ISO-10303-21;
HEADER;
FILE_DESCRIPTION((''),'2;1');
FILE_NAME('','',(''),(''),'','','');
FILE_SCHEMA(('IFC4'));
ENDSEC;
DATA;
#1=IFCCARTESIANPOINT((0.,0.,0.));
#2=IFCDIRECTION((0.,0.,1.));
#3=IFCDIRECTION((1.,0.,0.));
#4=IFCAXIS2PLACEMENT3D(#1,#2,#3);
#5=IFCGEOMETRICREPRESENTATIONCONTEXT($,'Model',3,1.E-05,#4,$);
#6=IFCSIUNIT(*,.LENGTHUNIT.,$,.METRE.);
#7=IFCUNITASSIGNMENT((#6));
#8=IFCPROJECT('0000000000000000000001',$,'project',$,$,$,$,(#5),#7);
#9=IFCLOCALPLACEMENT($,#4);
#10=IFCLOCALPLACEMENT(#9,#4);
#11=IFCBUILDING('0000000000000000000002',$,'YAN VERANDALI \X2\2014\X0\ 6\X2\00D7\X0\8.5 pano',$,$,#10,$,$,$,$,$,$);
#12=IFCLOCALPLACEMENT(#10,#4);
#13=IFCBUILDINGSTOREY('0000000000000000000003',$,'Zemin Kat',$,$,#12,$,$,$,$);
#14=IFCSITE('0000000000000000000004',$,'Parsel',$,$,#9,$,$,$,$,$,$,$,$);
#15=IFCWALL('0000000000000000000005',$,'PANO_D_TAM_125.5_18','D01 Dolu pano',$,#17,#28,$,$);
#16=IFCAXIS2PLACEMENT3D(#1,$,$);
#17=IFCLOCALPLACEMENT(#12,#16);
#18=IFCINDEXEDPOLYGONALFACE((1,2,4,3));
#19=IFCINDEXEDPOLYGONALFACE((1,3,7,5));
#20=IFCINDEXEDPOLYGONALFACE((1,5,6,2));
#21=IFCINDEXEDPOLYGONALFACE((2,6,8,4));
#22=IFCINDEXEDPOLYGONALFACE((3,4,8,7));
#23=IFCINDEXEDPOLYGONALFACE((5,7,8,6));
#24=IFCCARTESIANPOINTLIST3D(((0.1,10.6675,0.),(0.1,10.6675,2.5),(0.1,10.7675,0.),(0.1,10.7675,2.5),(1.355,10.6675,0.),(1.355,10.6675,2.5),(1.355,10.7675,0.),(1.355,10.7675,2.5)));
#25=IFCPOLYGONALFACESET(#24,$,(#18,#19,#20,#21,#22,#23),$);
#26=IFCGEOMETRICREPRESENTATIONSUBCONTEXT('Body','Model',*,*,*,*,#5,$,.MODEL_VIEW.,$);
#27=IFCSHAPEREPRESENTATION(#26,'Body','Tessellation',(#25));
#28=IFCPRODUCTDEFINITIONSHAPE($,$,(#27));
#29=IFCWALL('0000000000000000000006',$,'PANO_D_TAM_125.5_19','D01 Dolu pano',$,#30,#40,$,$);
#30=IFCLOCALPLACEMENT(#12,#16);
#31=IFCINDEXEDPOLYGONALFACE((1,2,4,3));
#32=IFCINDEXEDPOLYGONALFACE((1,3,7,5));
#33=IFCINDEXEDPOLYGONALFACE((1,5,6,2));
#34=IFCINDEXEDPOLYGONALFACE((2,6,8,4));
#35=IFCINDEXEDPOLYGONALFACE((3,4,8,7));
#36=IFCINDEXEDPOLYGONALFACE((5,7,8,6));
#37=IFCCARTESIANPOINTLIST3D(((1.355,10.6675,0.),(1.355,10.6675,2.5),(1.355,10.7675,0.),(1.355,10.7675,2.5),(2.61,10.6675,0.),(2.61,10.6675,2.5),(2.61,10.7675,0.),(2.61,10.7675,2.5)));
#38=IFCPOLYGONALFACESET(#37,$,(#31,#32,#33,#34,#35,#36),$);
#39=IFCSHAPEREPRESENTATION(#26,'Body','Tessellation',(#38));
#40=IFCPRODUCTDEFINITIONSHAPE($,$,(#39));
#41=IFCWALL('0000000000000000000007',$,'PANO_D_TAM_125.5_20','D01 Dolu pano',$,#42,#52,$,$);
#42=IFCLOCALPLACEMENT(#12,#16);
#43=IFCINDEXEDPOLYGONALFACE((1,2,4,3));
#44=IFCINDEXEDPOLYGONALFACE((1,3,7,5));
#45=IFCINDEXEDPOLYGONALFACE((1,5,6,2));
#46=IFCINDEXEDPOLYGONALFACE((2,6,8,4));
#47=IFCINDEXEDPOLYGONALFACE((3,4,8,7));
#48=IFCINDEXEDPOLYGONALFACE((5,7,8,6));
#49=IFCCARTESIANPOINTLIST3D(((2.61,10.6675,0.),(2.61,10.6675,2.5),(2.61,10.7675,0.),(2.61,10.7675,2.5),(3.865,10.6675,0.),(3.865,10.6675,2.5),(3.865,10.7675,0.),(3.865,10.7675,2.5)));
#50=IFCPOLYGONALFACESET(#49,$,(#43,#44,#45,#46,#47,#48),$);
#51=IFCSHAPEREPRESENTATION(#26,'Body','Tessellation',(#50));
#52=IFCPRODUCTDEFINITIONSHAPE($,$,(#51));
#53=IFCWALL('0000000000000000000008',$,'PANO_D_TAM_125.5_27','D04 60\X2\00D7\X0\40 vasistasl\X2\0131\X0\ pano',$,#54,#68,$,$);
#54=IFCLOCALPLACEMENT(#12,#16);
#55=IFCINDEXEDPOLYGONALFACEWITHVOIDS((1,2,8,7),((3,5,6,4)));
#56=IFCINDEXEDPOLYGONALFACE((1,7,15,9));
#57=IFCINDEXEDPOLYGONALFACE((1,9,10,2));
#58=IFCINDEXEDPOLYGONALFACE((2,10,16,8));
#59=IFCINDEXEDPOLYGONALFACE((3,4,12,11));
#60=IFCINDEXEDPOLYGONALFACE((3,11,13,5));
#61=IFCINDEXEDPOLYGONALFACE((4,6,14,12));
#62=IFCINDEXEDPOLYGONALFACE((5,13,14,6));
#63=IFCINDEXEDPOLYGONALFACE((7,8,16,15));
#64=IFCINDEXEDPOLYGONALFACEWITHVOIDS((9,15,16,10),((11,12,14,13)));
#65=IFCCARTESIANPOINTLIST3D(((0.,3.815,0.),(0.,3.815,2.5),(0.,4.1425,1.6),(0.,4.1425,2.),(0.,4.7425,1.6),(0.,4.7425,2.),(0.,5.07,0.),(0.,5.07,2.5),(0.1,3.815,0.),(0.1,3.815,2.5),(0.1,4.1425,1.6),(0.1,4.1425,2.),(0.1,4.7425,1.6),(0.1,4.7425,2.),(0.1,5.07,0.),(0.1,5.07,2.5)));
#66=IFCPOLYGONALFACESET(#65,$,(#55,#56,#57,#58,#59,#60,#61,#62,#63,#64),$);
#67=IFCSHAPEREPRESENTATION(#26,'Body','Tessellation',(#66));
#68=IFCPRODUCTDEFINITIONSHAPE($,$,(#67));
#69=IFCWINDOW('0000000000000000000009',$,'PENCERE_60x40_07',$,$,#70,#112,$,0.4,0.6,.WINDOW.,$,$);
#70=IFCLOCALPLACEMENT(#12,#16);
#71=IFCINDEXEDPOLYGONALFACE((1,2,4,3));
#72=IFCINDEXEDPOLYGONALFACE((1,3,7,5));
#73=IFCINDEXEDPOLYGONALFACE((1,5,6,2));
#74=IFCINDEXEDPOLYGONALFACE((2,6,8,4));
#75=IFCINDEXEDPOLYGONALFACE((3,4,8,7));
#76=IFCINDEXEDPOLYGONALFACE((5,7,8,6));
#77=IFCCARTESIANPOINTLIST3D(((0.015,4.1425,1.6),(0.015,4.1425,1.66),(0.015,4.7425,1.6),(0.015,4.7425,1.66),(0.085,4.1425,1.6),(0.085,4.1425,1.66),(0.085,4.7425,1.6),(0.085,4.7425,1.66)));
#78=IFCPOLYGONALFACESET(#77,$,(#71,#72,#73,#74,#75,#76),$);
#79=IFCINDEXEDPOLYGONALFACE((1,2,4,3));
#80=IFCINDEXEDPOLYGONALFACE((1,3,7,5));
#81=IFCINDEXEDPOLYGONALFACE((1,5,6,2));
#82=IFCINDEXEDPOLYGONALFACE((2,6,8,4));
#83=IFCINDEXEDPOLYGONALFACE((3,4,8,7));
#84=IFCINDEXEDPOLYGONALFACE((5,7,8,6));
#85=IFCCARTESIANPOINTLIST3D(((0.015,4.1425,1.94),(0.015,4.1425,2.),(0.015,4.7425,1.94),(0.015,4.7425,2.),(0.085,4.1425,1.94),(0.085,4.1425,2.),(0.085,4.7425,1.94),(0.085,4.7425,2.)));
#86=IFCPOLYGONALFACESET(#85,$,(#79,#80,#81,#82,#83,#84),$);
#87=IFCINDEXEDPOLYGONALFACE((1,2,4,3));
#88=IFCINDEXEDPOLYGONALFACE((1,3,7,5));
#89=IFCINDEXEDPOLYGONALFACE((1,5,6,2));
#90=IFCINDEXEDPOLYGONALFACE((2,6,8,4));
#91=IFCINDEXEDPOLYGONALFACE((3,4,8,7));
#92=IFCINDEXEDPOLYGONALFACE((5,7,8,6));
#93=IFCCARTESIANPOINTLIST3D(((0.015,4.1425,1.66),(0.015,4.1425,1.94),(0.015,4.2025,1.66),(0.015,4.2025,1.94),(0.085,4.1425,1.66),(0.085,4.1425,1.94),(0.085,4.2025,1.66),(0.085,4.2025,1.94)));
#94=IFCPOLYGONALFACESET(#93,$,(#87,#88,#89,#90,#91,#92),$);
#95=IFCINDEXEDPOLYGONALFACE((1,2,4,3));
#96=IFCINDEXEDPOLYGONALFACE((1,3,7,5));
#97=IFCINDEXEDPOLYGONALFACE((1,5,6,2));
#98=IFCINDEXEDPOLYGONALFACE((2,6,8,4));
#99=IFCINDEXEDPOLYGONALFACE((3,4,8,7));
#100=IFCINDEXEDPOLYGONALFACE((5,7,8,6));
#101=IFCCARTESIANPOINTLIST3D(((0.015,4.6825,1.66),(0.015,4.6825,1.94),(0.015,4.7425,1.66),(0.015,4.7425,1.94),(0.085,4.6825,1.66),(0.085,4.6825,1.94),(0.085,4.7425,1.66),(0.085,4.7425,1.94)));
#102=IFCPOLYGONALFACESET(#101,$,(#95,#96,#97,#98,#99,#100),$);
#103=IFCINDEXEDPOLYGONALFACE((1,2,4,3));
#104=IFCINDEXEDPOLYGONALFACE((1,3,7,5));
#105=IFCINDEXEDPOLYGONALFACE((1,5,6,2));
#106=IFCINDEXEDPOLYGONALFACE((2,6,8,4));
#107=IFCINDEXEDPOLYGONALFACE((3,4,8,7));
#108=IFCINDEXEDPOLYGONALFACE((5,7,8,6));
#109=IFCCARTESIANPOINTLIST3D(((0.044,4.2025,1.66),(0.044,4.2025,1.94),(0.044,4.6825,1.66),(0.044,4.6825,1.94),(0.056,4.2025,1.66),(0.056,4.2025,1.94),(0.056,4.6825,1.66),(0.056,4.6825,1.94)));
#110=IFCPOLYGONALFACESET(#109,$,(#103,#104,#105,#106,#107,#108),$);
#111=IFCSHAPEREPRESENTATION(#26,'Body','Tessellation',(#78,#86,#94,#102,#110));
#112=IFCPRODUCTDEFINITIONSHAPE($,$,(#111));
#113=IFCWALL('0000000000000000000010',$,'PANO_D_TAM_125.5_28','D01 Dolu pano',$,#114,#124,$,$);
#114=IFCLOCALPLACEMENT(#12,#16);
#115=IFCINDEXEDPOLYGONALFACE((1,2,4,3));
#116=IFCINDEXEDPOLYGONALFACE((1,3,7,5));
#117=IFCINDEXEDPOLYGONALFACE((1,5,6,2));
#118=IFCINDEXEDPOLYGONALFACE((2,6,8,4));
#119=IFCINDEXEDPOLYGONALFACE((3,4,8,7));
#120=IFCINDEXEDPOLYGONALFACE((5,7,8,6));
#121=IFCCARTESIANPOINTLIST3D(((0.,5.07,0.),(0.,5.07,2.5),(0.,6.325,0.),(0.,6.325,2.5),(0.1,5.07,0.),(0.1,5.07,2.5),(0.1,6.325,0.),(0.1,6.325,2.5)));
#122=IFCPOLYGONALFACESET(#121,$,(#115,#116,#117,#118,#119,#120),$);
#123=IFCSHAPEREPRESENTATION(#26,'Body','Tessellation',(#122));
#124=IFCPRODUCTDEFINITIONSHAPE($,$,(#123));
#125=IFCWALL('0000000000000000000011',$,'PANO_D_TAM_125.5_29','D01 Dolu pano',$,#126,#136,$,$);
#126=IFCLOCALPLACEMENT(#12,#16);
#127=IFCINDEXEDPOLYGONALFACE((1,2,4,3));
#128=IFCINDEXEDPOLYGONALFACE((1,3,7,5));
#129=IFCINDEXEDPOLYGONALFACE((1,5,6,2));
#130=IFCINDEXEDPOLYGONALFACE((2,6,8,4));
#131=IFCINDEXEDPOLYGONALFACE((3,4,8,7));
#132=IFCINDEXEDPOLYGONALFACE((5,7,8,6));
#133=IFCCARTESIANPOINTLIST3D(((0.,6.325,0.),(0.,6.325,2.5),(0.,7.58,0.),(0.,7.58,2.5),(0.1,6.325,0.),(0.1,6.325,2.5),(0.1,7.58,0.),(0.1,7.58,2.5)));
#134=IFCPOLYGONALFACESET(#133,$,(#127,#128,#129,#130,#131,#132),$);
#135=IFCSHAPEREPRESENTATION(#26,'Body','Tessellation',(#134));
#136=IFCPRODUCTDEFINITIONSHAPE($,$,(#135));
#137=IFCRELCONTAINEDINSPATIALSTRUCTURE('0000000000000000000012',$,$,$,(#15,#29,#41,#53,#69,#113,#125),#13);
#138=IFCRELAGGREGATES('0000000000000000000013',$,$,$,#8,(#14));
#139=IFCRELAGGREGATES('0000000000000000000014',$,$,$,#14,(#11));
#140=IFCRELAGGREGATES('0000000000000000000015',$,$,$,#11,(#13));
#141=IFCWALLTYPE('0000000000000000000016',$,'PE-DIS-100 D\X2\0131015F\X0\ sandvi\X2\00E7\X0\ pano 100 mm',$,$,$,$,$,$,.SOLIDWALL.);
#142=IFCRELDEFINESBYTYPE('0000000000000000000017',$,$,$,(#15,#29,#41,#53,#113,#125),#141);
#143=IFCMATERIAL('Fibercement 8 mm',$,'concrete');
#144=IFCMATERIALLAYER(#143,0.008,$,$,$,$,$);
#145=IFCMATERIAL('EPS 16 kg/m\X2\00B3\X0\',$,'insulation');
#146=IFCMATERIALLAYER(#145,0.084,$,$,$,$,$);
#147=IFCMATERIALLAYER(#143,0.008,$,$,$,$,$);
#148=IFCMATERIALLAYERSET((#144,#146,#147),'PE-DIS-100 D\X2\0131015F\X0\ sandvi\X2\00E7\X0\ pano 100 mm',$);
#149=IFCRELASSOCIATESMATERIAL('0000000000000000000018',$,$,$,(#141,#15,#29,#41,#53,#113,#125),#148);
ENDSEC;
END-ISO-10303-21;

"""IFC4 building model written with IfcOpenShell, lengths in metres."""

from ifc_helpers import new_model, si_unit, frame, origin_with_axes, place, context, subcontext, project, spatial, line, indexed_curve, outline, extrude, material, layer, layer_set, layer_usage, type_object, element, fill, save


model = new_model("IFC4")

# Units and contexts
model_context = context("Model", 3, precision=1e-05, world=origin_with_axes())
body_context = subcontext(model_context, "Body", "Model", "MODEL_VIEW")
ifc_project = project(units=[si_unit("LENGTHUNIT", "METRE")], contexts=[model_context])

# Site, building, storey
site_placement = place(None, origin_with_axes())
site = spatial("IfcSite", under=ifc_project, at=site_placement, Name="Parsel")
building_placement = place(site_placement, origin_with_axes())
building = spatial("IfcBuilding", under=site, at=building_placement, Name="YAN VERANDALI — 6×8.5 pano")
storey_placement = place(building_placement, origin_with_axes())
storey = spatial("IfcBuildingStorey", under=building, at=storey_placement, Name="Zemin Kat")

# Walls
ifc_material_1 = material(Name="Fibercement 8 mm", Category="concrete")
ifc_layer_1 = layer(ifc_material_1, 0.008)
ifc_material_2 = material(Name="EPS 16 kg/m³", Category="insulation")
ifc_layer_2 = layer(ifc_material_2, 0.084)
ifc_layer_3 = layer(ifc_material_1, 0.008)
ifc_layer_set_1 = layer_set([ifc_layer_1, ifc_layer_2, ifc_layer_3], Name="PE-DIS-100 Dış sandviç pano 100 mm")
ifc_layer_usage_1 = layer_usage(ifc_layer_set_1, "AXIS2", "POSITIVE", 0.0)
wall_type_1 = type_object("IfcWallType", Name="PE-DIS-100 Dış sandviç pano 100 mm", PredefinedType="SOLIDWALL", material=ifc_layer_set_1)
wall_1_placement = place(storey_placement, frame((0.1, 10.6675, 0.0), z_axis=(0.0, 0.0, 1.0), x_axis=(1.0, 0.0, 0.0)))
element("IfcWall", 1, at=wall_1_placement, inside=storey, type_object=wall_type_1, material=ifc_layer_usage_1, Name="PANO_D_TAM_125.5_18", Description="D01 Dolu pano", context=body_context, shape_type="SweptSolid", body=[
    extrude(outline(indexed_curve([(0.0, 0.0), (1.255, 0.0), (1.255, 0.1), (0.0, 0.1)], segments=[line(1, 2, 3, 4, 1)])), origin_with_axes(), (0.0, 0.0, 1.0), 2.5),
])
ifc_layer_usage_2 = layer_usage(ifc_layer_set_1, "AXIS2", "POSITIVE", 0.0)
wall_2_placement = place(storey_placement, frame((1.355, 10.6675, 0.0), z_axis=(0.0, 0.0, 1.0), x_axis=(1.0, 0.0, 0.0)))
element("IfcWall", 2, at=wall_2_placement, inside=storey, type_object=wall_type_1, material=ifc_layer_usage_2, Name="PANO_D_TAM_125.5_19", Description="D01 Dolu pano", context=body_context, shape_type="SweptSolid", body=[
    extrude(outline(indexed_curve([(0.0, 0.0), (1.255, 0.0), (1.255, 0.1), (0.0, 0.1)], segments=[line(1, 2, 3, 4, 1)])), origin_with_axes(), (0.0, 0.0, 1.0), 2.5),
])
ifc_layer_usage_3 = layer_usage(ifc_layer_set_1, "AXIS2", "POSITIVE", 0.0)
wall_3_placement = place(storey_placement, frame((2.61, 10.6675, 0.0), z_axis=(0.0, 0.0, 1.0), x_axis=(1.0, 0.0, 0.0)))
element("IfcWall", 3, at=wall_3_placement, inside=storey, type_object=wall_type_1, material=ifc_layer_usage_3, Name="PANO_D_TAM_125.5_20", Description="D01 Dolu pano", context=body_context, shape_type="SweptSolid", body=[
    extrude(outline(indexed_curve([(0.0, 0.0), (1.255, 0.0), (1.255, 0.1), (0.0, 0.1)], segments=[line(1, 2, 3, 4, 1)])), origin_with_axes(), (0.0, 0.0, 1.0), 2.5),
])

# Wall, opening, window
ifc_layer_usage_4 = layer_usage(ifc_layer_set_1, "AXIS2", "POSITIVE", 0.0)
wall_4_placement = place(storey_placement, frame((0.1, 3.815, 0.0), z_axis=(0.0, 0.0, 1.0), x_axis=(0.0, 1.0, 0.0)))
wall_4 = element("IfcWall", 4, at=wall_4_placement, inside=storey, type_object=wall_type_1, material=ifc_layer_usage_4, Name="PANO_D_TAM_125.5_27", Description="D04 60×40 vasistaslı pano", context=body_context, shape_type="SweptSolid", body=[
    extrude(outline(indexed_curve([(0.0, 0.0), (1.255, 0.0), (1.255, 0.1), (0.0, 0.1)], segments=[line(1, 2, 3, 4, 1)])), origin_with_axes(), (0.0, 0.0, 1.0), 2.5),
])
opening_1_placement = place(wall_4_placement, origin_with_axes())
opening_1 = element("IfcOpeningElement", 5, at=opening_1_placement, cuts=wall_4, PredefinedType="OPENING", context=body_context, shape_type="SweptSolid", body=[
    extrude(outline(indexed_curve([(0.0, 0.0), (0.6, 0.0), (0.6, 0.14), (0.0, 0.14)], segments=[line(1, 2, 3, 4, 1)])), frame((0.3275, -0.02, 1.6), z_axis=(0.0, 0.0, 1.0), x_axis=(1.0, 0.0, 0.0)), (0.0, 0.0, 1.0), 0.4),
])
window_1_placement = place(storey_placement, frame((0.1, 3.815, 0.0), z_axis=(0.0, 0.0, 1.0), x_axis=(0.0, 1.0, 0.0)))
window_1 = element("IfcWindow", 6, at=window_1_placement, inside=storey, Name="PENCERE_60x40_07", OverallHeight=0.4, OverallWidth=0.6, PredefinedType="WINDOW", context=body_context, shape_type="SweptSolid", body=[
    extrude(outline(indexed_curve([(0.0, 0.0), (0.6, 0.0), (0.6, 0.07), (0.0, 0.07)], segments=[line(1, 2, 3, 4, 1)])), frame((0.3275, 0.015, 1.6), z_axis=(0.0, 0.0, 1.0), x_axis=(1.0, 0.0, 0.0)), (0.0, 0.0, 1.0), 0.06),
    extrude(outline(indexed_curve([(0.0, 0.0), (0.6, 0.0), (0.6, 0.07), (0.0, 0.07)], segments=[line(1, 2, 3, 4, 1)])), frame((0.3275, 0.015, 1.94), z_axis=(0.0, 0.0, 1.0), x_axis=(1.0, 0.0, 0.0)), (0.0, 0.0, 1.0), 0.06),
    extrude(outline(indexed_curve([(0.0, 0.0), (0.06, 0.0), (0.06, 0.07), (0.0, 0.07)], segments=[line(1, 2, 3, 4, 1)])), frame((0.3275, 0.015, 1.66), z_axis=(0.0, 0.0, 1.0), x_axis=(1.0, 0.0, 0.0)), (0.0, 0.0, 1.0), 0.28),
    extrude(outline(indexed_curve([(0.0, 0.0), (0.06, 0.0), (0.06, 0.07), (0.0, 0.07)], segments=[line(1, 2, 3, 4, 1)])), frame((0.8675, 0.015, 1.66), z_axis=(0.0, 0.0, 1.0), x_axis=(1.0, 0.0, 0.0)), (0.0, 0.0, 1.0), 0.28),
    extrude(outline(indexed_curve([(0.0, 0.0), (0.48, 0.0), (0.48, 0.012), (0.0, 0.012)], segments=[line(1, 2, 3, 4, 1)])), frame((0.3875, 0.044, 1.66), z_axis=(0.0, 0.0, 1.0), x_axis=(1.0, 0.0, 0.0)), (0.0, 0.0, 1.0), 0.28),
])
fill(opening_1, window_1)

# Walls
ifc_layer_usage_5 = layer_usage(ifc_layer_set_1, "AXIS2", "POSITIVE", 0.0)
wall_5_placement = place(storey_placement, frame((0.1, 5.07, 0.0), z_axis=(0.0, 0.0, 1.0), x_axis=(0.0, 1.0, 0.0)))
element("IfcWall", 7, at=wall_5_placement, inside=storey, type_object=wall_type_1, material=ifc_layer_usage_5, Name="PANO_D_TAM_125.5_28", Description="D01 Dolu pano", context=body_context, shape_type="SweptSolid", body=[
    extrude(outline(indexed_curve([(0.0, 0.0), (1.255, 0.0), (1.255, 0.1), (0.0, 0.1)], segments=[line(1, 2, 3, 4, 1)])), origin_with_axes(), (0.0, 0.0, 1.0), 2.5),
])
ifc_layer_usage_6 = layer_usage(ifc_layer_set_1, "AXIS2", "POSITIVE", 0.0)
wall_6_placement = place(storey_placement, frame((0.1, 6.325, 0.0), z_axis=(0.0, 0.0, 1.0), x_axis=(0.0, 1.0, 0.0)))
element("IfcWall", 8, at=wall_6_placement, inside=storey, type_object=wall_type_1, material=ifc_layer_usage_6, Name="PANO_D_TAM_125.5_29", Description="D01 Dolu pano", context=body_context, shape_type="SweptSolid", body=[
    extrude(outline(indexed_curve([(0.0, 0.0), (1.255, 0.0), (1.255, 0.1), (0.0, 0.1)], segments=[line(1, 2, 3, 4, 1)])), origin_with_axes(), (0.0, 0.0, 1.0), 2.5),
])

save(model, "model.ifc")
